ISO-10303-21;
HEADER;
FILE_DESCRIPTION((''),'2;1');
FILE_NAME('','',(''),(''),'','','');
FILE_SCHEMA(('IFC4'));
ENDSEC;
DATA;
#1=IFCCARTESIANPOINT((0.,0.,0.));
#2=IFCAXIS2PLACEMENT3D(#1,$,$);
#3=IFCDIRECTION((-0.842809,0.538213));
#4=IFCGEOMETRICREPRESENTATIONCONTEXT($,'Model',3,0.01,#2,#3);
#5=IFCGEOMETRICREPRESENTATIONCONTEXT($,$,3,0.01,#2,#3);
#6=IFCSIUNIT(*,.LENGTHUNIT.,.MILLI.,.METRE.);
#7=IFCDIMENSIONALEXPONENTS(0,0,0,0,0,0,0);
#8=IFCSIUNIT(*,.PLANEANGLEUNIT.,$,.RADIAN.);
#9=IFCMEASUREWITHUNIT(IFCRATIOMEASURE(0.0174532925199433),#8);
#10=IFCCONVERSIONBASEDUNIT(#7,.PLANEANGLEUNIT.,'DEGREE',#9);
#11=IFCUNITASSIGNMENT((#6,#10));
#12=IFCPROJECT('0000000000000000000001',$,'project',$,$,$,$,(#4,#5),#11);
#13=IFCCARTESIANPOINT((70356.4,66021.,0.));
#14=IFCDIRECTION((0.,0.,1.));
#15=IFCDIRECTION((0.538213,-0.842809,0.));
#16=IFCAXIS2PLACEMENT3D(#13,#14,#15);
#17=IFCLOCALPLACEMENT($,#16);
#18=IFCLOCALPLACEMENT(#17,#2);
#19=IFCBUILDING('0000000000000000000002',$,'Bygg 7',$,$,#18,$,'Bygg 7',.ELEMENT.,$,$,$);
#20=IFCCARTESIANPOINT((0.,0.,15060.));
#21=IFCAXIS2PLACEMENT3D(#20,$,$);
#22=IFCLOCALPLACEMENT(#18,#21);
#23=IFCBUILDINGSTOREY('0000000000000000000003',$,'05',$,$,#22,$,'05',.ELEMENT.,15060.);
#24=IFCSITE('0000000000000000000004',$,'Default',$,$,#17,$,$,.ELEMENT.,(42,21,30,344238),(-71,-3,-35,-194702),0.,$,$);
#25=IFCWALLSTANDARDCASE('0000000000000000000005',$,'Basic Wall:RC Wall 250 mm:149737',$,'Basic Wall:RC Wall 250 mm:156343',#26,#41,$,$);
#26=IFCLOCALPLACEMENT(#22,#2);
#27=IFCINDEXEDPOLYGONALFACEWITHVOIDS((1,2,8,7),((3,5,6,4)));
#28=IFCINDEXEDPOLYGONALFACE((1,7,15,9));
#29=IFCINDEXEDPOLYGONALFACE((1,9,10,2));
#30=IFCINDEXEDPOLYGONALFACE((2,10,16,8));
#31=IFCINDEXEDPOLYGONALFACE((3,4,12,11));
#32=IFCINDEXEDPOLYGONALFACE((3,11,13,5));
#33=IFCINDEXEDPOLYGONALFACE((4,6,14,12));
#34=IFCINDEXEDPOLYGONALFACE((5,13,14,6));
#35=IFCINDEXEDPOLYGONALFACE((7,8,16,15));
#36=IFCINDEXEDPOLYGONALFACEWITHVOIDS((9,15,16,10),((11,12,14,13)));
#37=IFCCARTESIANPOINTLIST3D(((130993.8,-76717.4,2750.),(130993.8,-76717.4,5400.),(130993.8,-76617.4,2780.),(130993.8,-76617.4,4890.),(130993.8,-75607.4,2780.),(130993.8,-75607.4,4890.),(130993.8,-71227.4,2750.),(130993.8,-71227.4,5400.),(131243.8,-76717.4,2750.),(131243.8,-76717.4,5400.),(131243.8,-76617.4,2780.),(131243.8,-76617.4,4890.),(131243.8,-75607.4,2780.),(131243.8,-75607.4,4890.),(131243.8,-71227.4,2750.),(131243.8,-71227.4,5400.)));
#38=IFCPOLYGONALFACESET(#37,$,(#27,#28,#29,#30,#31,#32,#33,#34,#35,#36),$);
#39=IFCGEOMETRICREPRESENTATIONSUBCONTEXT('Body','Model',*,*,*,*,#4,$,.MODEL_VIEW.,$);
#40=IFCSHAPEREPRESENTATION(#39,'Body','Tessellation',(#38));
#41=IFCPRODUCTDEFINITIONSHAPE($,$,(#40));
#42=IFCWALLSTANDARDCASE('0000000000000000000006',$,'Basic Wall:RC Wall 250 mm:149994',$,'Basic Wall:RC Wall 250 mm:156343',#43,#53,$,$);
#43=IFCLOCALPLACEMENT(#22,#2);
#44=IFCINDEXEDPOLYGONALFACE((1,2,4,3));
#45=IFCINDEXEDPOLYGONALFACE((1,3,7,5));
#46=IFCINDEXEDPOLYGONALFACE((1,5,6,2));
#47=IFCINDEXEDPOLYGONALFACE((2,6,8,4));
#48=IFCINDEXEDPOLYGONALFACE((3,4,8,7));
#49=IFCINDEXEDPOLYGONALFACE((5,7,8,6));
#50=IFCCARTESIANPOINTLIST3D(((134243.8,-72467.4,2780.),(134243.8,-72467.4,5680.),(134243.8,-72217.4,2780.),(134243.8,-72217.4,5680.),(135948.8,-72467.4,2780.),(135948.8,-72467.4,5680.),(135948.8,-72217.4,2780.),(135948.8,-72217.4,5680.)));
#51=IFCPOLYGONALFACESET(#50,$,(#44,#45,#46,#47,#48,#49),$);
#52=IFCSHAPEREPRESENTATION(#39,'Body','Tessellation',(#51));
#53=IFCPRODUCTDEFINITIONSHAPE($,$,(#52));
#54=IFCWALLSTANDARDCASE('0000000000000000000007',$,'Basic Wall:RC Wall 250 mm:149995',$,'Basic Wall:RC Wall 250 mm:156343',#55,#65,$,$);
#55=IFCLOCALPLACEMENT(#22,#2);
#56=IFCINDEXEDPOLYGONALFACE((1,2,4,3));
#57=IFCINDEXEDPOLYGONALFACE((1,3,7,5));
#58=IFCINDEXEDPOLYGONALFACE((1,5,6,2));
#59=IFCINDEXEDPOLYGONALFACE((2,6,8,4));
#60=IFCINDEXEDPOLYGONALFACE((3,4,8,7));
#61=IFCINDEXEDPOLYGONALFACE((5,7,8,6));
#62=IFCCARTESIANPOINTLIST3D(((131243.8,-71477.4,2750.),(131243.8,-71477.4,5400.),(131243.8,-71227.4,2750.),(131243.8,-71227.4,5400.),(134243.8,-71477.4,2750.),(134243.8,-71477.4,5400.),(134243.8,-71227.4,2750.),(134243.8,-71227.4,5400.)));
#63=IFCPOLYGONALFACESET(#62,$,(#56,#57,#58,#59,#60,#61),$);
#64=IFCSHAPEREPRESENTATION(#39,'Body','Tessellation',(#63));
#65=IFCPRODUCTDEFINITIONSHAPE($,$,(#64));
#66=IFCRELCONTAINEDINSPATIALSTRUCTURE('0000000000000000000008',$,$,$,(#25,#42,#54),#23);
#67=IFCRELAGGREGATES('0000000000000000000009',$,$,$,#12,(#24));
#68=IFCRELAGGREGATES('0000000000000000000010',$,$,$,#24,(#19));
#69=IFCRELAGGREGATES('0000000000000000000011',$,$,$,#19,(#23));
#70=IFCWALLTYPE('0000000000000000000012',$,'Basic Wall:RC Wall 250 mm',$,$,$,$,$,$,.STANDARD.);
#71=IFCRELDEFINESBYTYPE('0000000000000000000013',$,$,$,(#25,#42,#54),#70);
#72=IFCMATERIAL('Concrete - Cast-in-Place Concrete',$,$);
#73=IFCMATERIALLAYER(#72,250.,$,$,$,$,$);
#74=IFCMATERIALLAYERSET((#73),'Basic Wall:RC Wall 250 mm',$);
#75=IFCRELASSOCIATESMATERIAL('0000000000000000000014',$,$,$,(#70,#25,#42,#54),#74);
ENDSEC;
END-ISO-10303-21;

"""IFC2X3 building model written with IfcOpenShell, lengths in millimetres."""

from ifc_helpers import new_model, entity, si_unit, converted_unit, direction, frame, frame_2d, origin, origin_2d_with_axis, place, context, subcontext, project, spatial, polyline, rectangle, extrude, clip, bounded_halfspace, material, layer, layer_set, layer_usage, type_object, element, save


model = new_model("IFC2X3")

# Units and contexts
model_context = context("Model", 3, precision=0.01, world=origin(), true_north=direction((-0.842809, 0.538213)))
context_of_model = context(None, 3, precision=0.01, world=origin(), true_north=direction((-0.842809, 0.538213)))
body_context = subcontext(model_context, "Body", "Model", "MODEL_VIEW")
ifc_project = project(units=[si_unit("LENGTHUNIT", "METRE", prefix="MILLI"), converted_unit("PLANEANGLEUNIT", "DEGREE", entity("IfcRatioMeasure", 0.0174532925199433), si_unit("PLANEANGLEUNIT", "RADIAN"), dimensions=[0, 0, 0, 0, 0, 0, 0])], contexts=[model_context, context_of_model])

# Site, building, storey
site_placement = place(None, frame((70356.4, 66021.0, 0.0), z_axis=(0.0, 0.0, 1.0), x_axis=(0.538213, -0.842809, 0.0)))
site = spatial("IfcSite", under=ifc_project, at=site_placement, Name="Default", CompositionType="ELEMENT", RefLatitude=(42, 21, 30, 344238), RefLongitude=(-71, -3, -35, -194702), RefElevation=0.0)
building_placement = place(site_placement, origin())
building = spatial("IfcBuilding", under=site, at=building_placement, Name="Bygg 7", LongName="Bygg 7", CompositionType="ELEMENT")
storey_placement = place(building_placement, frame((0.0, 0.0, 15060.0)))
storey = spatial("IfcBuildingStorey", under=building, at=storey_placement, Name="05", LongName="05", CompositionType="ELEMENT", Elevation=15060.0)

# Shared definitions
ifc_material_1 = material(Name="Concrete - Cast-in-Place Concrete")

# Wall, opening
ifc_layer_1 = layer(ifc_material_1, 250.0)
ifc_layer_set_1 = layer_set([ifc_layer_1], Name="Basic Wall:RC Wall 250 mm")
wall_type_1 = type_object("IfcWallType", Name="Basic Wall:RC Wall 250 mm", PredefinedType="STANDARD", material=ifc_layer_set_1)
ifc_layer_usage_1 = layer_usage(ifc_layer_set_1, "AXIS2", "NEGATIVE", 125.0)
wall_1_placement = place(storey_placement, frame((131118.8, -76717.4, 2750.0), z_axis=(0.0, 0.0, 1.0), x_axis=(0.0, 1.0, 0.0)))
wall_1 = element("IfcWallStandardCase", 1, at=wall_1_placement, inside=storey, type_object=wall_type_1, material=ifc_layer_usage_1, Name="Basic Wall:RC Wall 250 mm:149737", ObjectType="Basic Wall:RC Wall 250 mm:156343", context=body_context, shape_type="SweptSolid", body=[
    extrude(rectangle(XDim=5490.0, YDim=250.0, at=frame_2d((2745.0, 0.0), x_axis=(-1.0, 0.0))), origin(), (0.0, 0.0, 1.0), 2650.0),
])
opening_1_placement = place(wall_1_placement, origin())
element("IfcOpeningElement", 2, at=opening_1_placement, cuts=wall_1, ObjectType="Opening", context=body_context, shape_type="SweptSolid", body=[
    extrude(rectangle(XDim=2110.0, YDim=1010.0, at=origin_2d_with_axis()), frame((605.0, -125.0, 1085.0), z_axis=(0.0, 1.0, 0.0), x_axis=(0.0, 0.0, -1.0)), (0.0, 0.0, 1.0), 250.0),
])

# Walls
ifc_layer_usage_2 = layer_usage(ifc_layer_set_1, "AXIS2", "NEGATIVE", 125.0)
wall_2_placement = place(storey_placement, frame((134243.8, -72342.4, 2780.0)))
element("IfcWallStandardCase", 3, at=wall_2_placement, inside=storey, type_object=wall_type_1, material=ifc_layer_usage_2, Name="Basic Wall:RC Wall 250 mm:149994", ObjectType="Basic Wall:RC Wall 250 mm:156343", context=body_context, shape_type="SweptSolid", body=[
    extrude(rectangle(XDim=1705.0, YDim=250.0, at=frame_2d((852.5, 0.0), x_axis=(-1.0, 0.0))), origin(), (0.0, 0.0, 1.0), 2900.0),
])
ifc_layer_usage_3 = layer_usage(ifc_layer_set_1, "AXIS2", "NEGATIVE", 125.0)
wall_3_placement = place(storey_placement, frame((131243.8, -71352.4, 2750.0)))
element("IfcWallStandardCase", 4, at=wall_3_placement, inside=storey, type_object=wall_type_1, material=ifc_layer_usage_3, Name="Basic Wall:RC Wall 250 mm:149995", ObjectType="Basic Wall:RC Wall 250 mm:156343", context=body_context, shape_type="Clipping", body=[
    clip(extrude(rectangle(XDim=3000.0, YDim=250.0, at=frame_2d((1500.0, 0.0), x_axis=(-1.0, 0.0))), origin(), (0.0, 0.0, 1.0), 2650.0), bounded_halfspace(frame((3000.0, -125.0, 0.0), z_axis=(0.0, 0.0, 1.0), x_axis=(-0.092529, 0.99571, 0.0)), True, frame((3000.0, -125.0, 0.0)), polyline([(0.0, 0.0), (0.0, 250.0), (-3000.0, 250.0), (-3000.0, 0.0), (-250.0, 0.0), (0.0, 0.0)]))),
])

save(model, "model.ifc")
